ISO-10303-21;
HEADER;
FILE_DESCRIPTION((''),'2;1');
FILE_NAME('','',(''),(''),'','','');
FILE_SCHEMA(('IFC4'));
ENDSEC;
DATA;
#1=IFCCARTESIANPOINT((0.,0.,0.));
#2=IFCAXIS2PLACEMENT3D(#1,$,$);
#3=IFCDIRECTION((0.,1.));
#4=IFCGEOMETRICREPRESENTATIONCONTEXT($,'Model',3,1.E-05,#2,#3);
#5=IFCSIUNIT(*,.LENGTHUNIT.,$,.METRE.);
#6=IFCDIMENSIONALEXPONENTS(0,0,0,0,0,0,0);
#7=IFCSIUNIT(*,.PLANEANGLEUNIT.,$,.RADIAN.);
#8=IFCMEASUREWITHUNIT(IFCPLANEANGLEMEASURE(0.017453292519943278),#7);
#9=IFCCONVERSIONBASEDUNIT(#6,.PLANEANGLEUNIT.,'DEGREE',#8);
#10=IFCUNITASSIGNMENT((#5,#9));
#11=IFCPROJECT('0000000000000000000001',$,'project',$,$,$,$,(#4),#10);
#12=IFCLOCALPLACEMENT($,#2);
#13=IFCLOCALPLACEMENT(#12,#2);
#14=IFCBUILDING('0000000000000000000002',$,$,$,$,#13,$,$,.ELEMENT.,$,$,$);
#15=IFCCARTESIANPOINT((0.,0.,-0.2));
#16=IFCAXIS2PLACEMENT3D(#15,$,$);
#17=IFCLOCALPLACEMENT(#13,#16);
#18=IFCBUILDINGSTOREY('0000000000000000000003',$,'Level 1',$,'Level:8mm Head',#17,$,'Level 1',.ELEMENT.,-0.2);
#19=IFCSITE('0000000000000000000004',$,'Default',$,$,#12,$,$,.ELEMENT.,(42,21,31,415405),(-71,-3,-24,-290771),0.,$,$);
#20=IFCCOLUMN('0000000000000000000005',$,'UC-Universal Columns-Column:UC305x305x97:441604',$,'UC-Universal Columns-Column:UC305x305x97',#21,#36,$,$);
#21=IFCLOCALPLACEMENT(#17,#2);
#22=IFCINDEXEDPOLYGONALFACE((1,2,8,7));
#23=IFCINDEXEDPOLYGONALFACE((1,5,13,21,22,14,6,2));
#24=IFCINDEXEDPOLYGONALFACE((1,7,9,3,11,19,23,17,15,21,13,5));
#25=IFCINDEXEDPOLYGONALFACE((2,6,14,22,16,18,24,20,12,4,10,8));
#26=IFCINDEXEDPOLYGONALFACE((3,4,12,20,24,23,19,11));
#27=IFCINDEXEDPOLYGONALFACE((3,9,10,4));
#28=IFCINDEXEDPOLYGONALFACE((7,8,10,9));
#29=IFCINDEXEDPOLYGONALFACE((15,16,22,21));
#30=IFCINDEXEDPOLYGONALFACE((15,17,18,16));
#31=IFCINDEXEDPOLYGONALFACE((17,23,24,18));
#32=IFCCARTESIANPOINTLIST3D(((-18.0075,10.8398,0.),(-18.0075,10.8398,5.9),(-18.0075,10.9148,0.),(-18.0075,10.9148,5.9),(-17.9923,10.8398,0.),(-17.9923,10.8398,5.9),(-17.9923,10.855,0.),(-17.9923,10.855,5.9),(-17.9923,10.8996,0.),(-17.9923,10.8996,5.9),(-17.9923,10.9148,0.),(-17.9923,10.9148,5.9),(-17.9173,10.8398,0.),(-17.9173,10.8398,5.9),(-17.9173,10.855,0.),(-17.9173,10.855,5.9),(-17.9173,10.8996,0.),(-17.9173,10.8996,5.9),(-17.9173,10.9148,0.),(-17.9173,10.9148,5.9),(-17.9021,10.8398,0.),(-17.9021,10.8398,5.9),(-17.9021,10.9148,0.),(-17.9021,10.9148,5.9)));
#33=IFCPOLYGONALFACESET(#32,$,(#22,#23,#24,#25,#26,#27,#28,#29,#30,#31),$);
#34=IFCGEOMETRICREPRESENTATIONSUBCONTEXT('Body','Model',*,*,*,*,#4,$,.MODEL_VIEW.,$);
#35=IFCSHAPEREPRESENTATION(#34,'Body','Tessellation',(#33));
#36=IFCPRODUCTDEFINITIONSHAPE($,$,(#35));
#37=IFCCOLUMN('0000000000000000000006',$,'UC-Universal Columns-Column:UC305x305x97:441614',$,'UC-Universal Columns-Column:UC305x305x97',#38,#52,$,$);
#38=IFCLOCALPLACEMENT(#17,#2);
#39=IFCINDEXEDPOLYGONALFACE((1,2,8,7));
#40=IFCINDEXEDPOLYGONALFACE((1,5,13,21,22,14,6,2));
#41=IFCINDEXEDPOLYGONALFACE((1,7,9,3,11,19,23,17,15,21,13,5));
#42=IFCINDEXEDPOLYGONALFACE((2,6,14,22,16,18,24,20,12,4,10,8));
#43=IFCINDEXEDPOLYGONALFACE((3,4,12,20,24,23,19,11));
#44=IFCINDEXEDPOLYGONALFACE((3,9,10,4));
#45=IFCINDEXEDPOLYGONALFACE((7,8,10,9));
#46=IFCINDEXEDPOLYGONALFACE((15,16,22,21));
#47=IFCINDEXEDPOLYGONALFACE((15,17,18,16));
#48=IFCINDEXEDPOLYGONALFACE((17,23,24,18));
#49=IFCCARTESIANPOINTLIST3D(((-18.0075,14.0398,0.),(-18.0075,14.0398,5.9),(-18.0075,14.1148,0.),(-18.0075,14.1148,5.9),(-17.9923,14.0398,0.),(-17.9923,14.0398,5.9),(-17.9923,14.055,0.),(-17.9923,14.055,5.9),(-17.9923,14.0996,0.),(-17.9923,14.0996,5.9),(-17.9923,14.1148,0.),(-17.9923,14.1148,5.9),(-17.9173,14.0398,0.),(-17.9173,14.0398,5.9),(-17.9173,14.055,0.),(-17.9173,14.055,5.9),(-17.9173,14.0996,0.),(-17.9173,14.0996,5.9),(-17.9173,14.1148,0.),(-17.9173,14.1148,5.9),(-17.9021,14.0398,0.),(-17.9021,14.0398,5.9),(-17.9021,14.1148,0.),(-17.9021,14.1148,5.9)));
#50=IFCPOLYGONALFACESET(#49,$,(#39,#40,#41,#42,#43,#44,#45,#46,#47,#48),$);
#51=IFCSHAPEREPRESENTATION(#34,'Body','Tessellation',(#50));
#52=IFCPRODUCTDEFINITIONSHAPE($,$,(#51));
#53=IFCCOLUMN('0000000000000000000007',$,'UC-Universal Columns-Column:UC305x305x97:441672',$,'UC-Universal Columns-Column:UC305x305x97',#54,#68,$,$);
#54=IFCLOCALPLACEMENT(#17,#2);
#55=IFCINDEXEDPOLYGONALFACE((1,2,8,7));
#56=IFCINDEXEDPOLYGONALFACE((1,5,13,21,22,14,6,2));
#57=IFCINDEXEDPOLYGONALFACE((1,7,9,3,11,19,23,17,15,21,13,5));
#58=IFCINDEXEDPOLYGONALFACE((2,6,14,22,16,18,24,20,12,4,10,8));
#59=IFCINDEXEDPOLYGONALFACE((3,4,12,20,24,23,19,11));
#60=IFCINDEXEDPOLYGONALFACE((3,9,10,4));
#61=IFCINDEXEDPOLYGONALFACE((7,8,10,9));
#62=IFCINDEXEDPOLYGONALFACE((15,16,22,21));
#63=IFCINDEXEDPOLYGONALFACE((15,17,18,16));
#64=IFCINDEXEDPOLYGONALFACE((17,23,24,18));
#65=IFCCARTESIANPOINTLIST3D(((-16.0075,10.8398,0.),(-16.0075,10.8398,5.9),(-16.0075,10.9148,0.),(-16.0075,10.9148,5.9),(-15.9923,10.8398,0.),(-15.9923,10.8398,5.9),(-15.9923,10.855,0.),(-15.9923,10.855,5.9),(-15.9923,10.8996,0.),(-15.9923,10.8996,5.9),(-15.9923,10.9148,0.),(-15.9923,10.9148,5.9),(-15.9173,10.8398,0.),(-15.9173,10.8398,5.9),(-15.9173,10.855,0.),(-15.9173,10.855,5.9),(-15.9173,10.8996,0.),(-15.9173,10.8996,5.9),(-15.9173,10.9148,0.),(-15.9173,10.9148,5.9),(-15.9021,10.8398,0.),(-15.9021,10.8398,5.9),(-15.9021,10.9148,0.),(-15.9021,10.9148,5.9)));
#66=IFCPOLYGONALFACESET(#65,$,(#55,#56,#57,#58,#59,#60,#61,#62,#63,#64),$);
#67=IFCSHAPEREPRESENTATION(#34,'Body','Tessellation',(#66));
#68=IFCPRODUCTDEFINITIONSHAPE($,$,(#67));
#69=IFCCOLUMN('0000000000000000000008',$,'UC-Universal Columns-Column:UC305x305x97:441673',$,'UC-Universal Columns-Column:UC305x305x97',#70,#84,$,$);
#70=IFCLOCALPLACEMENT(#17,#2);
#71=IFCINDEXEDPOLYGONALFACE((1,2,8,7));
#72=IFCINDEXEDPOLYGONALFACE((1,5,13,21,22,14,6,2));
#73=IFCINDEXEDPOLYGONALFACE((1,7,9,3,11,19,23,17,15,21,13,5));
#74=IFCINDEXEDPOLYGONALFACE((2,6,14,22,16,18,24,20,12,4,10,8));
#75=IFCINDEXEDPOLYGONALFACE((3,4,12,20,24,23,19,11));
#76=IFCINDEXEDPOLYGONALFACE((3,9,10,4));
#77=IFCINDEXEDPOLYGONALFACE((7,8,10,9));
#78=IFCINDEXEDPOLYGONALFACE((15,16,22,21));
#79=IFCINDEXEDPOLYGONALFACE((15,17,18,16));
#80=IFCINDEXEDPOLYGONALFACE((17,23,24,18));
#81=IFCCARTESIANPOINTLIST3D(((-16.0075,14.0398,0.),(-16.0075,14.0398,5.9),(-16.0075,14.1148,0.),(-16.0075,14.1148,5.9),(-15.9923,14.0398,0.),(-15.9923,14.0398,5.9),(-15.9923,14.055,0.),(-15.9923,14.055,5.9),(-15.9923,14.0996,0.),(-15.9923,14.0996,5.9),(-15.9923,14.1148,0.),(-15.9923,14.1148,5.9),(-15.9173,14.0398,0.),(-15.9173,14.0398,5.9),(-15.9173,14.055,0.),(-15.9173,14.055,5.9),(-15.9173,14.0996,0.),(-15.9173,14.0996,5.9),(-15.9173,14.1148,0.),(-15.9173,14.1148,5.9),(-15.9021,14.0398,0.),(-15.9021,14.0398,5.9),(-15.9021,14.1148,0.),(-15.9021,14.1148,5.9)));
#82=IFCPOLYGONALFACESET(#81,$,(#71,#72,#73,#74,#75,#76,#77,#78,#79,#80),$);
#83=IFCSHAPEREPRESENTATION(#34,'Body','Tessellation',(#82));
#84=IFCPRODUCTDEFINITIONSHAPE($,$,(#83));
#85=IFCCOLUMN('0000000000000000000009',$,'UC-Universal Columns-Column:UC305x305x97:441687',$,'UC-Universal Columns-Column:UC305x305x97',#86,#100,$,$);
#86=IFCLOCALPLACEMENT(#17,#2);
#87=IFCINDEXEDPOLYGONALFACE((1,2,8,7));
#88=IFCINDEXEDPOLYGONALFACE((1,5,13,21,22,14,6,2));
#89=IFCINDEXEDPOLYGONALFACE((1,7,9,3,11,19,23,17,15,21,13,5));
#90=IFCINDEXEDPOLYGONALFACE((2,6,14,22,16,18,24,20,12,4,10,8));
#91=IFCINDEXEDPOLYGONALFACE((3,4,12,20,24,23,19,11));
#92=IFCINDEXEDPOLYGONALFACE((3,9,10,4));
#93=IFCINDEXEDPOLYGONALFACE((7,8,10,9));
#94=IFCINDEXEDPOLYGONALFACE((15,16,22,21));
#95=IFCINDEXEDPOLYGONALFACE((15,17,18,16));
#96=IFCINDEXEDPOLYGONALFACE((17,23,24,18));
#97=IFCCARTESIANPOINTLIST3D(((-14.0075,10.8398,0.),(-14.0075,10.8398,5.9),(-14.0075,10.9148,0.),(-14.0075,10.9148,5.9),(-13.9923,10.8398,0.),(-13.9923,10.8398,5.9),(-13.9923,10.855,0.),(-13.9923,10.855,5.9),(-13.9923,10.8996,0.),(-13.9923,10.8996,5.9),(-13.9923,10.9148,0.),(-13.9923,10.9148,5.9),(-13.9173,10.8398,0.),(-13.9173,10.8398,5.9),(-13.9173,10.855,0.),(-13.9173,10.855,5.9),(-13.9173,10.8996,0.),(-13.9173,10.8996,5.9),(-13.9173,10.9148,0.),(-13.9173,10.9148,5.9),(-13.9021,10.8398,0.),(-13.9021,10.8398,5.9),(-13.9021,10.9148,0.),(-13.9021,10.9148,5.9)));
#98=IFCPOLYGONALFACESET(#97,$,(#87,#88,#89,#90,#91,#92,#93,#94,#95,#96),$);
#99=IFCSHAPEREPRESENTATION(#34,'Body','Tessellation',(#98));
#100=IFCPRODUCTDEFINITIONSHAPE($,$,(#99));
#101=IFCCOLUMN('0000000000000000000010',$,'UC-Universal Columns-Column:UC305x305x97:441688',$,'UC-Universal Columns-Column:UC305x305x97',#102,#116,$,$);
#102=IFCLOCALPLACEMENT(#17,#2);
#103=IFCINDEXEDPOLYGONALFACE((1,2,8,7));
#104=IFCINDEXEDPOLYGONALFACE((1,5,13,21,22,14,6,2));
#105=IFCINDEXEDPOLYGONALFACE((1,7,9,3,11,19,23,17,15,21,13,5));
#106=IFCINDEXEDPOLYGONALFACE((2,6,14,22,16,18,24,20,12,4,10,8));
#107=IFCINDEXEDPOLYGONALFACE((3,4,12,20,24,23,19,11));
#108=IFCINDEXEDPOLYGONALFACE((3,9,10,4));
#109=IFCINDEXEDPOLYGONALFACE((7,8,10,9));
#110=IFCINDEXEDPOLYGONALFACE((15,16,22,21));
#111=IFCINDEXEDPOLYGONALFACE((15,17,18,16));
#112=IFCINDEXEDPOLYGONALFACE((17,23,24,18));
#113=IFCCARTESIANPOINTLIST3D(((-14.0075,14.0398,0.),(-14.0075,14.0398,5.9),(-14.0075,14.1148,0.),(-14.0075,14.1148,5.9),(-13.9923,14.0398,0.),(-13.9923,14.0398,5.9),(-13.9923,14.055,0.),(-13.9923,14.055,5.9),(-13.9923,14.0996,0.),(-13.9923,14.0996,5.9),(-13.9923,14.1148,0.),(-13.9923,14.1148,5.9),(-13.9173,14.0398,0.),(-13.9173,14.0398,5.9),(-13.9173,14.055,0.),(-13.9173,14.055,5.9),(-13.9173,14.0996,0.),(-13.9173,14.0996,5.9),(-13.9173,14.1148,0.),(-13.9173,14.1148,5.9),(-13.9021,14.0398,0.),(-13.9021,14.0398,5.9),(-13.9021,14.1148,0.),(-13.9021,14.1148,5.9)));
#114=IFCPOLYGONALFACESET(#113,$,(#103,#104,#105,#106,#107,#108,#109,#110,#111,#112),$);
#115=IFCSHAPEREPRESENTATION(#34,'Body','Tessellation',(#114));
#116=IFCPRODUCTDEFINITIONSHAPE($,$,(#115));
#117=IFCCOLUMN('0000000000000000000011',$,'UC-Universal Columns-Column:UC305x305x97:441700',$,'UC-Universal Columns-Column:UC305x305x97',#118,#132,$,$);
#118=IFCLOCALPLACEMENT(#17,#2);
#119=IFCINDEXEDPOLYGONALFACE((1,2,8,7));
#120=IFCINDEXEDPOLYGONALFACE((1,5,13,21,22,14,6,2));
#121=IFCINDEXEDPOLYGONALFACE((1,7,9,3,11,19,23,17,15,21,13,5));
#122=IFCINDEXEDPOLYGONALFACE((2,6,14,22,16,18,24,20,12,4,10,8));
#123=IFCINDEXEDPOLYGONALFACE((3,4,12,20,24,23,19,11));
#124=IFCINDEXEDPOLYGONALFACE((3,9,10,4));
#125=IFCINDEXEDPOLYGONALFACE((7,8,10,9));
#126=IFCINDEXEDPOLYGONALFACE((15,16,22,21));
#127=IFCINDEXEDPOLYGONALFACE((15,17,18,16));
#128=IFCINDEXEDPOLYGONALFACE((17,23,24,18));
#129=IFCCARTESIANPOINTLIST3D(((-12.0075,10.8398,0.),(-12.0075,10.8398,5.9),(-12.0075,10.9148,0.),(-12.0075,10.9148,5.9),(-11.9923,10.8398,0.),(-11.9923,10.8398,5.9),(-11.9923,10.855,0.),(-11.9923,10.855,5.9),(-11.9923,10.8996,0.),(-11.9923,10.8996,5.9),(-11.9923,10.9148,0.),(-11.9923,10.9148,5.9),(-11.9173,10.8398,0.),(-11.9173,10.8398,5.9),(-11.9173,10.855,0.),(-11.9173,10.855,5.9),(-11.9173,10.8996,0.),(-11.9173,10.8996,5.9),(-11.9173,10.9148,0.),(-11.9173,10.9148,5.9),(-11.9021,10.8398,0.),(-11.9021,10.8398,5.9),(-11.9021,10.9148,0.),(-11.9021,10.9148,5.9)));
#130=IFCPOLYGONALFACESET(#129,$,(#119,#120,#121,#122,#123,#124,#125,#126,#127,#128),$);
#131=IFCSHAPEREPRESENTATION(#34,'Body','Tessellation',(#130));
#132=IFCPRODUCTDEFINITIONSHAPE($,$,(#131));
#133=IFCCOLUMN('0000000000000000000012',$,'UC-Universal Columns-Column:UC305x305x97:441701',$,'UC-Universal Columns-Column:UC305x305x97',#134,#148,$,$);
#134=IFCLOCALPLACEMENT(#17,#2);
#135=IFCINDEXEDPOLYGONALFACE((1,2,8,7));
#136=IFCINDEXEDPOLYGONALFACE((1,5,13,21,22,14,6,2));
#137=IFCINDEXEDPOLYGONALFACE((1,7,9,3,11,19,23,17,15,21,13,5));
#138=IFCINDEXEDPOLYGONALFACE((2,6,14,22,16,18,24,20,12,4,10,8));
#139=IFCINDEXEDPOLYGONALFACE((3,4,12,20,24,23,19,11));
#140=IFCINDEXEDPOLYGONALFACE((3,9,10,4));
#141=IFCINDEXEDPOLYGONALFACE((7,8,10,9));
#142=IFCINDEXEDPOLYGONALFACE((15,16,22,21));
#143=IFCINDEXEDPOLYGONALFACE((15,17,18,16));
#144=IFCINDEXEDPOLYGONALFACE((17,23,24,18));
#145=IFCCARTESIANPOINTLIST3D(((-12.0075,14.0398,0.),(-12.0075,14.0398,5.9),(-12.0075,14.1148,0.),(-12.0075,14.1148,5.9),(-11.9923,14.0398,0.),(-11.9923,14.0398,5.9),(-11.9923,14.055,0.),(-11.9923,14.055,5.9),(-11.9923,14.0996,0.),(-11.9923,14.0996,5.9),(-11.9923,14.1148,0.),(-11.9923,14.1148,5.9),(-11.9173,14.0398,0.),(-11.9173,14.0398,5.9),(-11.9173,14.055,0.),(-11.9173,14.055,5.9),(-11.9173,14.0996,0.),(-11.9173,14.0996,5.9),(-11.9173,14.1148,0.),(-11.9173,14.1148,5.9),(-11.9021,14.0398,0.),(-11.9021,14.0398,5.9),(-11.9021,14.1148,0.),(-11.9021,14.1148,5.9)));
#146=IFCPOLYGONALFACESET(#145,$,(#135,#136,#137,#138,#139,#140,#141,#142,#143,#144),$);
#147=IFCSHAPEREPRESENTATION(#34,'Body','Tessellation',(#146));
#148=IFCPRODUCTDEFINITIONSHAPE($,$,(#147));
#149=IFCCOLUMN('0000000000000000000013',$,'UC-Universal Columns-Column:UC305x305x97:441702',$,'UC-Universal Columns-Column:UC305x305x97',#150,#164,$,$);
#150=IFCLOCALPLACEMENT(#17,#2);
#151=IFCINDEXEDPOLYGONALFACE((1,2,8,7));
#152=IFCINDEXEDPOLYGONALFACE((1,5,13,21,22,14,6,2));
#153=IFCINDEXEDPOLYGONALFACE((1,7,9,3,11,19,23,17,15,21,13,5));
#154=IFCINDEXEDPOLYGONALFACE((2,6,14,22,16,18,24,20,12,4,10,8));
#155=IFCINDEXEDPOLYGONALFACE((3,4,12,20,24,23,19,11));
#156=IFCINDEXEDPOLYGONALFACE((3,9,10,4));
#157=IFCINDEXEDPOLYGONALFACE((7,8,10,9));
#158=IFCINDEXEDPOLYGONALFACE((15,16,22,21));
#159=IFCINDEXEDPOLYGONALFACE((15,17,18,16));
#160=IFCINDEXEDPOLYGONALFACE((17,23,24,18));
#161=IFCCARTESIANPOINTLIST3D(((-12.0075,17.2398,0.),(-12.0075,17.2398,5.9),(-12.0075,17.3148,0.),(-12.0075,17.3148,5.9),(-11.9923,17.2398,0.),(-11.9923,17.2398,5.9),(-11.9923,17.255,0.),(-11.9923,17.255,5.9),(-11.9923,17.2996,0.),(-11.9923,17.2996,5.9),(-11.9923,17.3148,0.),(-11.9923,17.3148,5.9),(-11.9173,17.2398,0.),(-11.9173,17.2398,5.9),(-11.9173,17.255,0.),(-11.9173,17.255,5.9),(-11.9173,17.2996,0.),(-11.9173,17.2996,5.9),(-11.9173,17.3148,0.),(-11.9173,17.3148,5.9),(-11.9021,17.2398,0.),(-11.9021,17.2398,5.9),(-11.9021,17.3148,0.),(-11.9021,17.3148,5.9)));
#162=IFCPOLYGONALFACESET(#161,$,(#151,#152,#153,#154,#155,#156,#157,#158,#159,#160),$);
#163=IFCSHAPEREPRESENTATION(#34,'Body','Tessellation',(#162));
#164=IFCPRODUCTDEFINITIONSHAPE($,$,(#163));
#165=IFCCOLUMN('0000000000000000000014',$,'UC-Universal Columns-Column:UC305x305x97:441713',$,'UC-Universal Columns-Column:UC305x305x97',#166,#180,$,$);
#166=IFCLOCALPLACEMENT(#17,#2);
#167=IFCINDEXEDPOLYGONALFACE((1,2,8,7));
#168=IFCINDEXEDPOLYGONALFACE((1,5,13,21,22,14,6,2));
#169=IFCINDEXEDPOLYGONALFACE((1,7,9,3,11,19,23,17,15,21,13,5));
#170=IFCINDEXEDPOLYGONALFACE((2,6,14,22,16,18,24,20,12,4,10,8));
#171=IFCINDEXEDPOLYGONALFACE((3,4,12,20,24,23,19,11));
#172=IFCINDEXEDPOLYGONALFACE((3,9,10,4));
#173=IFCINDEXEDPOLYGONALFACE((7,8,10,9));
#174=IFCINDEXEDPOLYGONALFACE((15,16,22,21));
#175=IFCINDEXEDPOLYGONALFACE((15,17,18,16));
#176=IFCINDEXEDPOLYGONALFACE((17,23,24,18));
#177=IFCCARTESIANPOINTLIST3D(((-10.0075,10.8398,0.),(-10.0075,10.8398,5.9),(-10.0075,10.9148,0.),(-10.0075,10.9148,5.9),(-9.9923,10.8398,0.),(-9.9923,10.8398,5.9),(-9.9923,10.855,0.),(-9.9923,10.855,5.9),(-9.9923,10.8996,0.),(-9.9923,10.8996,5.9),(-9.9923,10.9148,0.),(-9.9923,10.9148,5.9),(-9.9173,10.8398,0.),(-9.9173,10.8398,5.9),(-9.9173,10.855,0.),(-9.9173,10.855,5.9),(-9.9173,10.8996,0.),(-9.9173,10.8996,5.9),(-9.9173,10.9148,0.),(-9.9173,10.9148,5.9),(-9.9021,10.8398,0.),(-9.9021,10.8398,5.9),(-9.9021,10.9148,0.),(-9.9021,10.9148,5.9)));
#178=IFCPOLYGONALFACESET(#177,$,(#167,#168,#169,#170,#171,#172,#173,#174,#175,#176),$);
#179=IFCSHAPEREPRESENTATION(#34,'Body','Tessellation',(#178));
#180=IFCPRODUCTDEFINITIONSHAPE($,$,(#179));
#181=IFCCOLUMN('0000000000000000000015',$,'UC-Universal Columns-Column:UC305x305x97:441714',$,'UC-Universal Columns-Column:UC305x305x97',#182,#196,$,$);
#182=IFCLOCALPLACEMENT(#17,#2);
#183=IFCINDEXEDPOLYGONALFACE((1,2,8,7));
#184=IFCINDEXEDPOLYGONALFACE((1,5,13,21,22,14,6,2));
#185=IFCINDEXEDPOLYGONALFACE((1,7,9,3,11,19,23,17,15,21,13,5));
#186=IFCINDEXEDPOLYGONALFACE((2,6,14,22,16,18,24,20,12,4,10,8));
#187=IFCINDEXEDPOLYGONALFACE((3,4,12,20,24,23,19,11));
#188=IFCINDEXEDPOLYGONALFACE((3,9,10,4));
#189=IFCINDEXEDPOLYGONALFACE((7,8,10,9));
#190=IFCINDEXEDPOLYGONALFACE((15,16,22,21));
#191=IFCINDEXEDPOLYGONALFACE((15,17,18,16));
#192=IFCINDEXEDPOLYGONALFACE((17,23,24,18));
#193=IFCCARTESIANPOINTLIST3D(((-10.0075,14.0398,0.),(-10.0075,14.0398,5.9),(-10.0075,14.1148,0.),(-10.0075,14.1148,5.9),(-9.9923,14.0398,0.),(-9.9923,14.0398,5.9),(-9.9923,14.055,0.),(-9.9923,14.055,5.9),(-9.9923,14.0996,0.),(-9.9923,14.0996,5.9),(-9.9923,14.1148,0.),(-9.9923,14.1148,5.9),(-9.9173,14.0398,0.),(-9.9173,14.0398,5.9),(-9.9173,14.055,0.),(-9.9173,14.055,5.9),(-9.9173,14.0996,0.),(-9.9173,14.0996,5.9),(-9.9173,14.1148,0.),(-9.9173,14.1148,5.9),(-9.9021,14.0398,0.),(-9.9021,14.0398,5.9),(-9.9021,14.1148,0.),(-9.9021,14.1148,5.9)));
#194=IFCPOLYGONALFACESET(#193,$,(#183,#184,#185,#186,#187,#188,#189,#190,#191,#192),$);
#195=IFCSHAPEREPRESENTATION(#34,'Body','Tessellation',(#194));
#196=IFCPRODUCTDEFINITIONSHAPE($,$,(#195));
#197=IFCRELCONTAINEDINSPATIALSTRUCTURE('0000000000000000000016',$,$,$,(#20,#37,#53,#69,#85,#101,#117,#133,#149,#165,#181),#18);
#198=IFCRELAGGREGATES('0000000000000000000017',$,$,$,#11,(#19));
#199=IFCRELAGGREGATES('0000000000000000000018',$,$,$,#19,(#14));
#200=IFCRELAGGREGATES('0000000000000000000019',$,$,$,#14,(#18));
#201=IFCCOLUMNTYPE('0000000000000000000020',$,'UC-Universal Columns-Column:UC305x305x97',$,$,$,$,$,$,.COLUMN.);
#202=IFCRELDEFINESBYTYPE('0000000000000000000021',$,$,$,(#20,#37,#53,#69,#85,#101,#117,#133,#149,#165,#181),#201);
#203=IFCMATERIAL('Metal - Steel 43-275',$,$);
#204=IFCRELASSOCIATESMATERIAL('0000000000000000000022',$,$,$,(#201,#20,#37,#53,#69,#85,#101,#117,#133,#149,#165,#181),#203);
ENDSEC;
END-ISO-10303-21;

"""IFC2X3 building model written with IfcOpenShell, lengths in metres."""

from ifc_helpers import new_model, entity, si_unit, converted_unit, direction, frame, frame_2d, origin, place, context, subcontext, project, spatial, polyline, circle_curve, parameter, trimmed, segment, composite_curve, outline, extrude, source, transform, mapped, material, type_object, type_shapes, element, save


model = new_model("IFC2X3")

# Units and contexts
model_context = context("Model", 3, precision=1e-05, world=origin(), true_north=direction((0.0, 1.0)))
body_context = subcontext(model_context, "Body", "Model", "MODEL_VIEW")
ifc_project = project(units=[si_unit("LENGTHUNIT", "METRE"), converted_unit("PLANEANGLEUNIT", "DEGREE", entity("IfcPlaneAngleMeasure", 0.017453292519943278), si_unit("PLANEANGLEUNIT", "RADIAN"), dimensions=[0, 0, 0, 0, 0, 0, 0])], contexts=[model_context])

# Site, building, storey
site_placement = place(None, origin())
site = spatial("IfcSite", under=ifc_project, at=site_placement, Name="Default", CompositionType="ELEMENT", RefLatitude=(42, 21, 31, 415405), RefLongitude=(-71, -3, -24, -290771), RefElevation=0.0)
building_placement = place(site_placement, origin())
building = spatial("IfcBuilding", under=site, at=building_placement, CompositionType="ELEMENT")
storey_placement = place(building_placement, frame((0.0, 0.0, -0.2)))
storey = spatial("IfcBuildingStorey", under=building, at=storey_placement, Name="Level 1", ObjectType="Level:8mm Head", LongName="Level 1", CompositionType="ELEMENT", Elevation=-0.2)

# Columns
ifc_material = material(Name="Metal - Steel 43-275")
column_type = type_object("IfcColumnType", Name="UC-Universal Columns-Column:UC305x305x97", PredefinedType="COLUMN", material=ifc_material)
shared_shape = source(origin(), body_context, "Body", "SweptSolid", [
    extrude(outline(composite_curve([segment(polyline([(-0.0375, -0.0375), (0.0375, -0.0375)]), True, "CONTINUOUS"), segment(polyline([(0.0375, -0.0375), (0.0527, -0.0375)]), True, "CONTINUOUS"), segment(trimmed(circle_curve(frame_2d((0.0527, -0.0223), x_axis=(-1.0, 0.0)), 0.0152), [parameter(0.0)], [parameter(90.0)], True, "PARAMETER"), False, "CONTINUOUS"), segment(polyline([(0.0375, -0.0223), (0.0375, 0.0223)]), True, "CONTINUOUS"), segment(trimmed(circle_curve(frame_2d((0.0527, 0.0223), x_axis=(-1.0, 0.0)), 0.0152), [parameter(270.0)], [parameter(0.0)], True, "PARAMETER"), False, "CONTINUOUS"), segment(polyline([(0.0527, 0.0375), (0.0375, 0.0375)]), True, "CONTINUOUS"), segment(polyline([(0.0375, 0.0375), (-0.0375, 0.0375)]), True, "CONTINUOUS"), segment(polyline([(-0.0375, 0.0375), (-0.0527, 0.0375)]), True, "CONTINUOUS"), segment(trimmed(circle_curve(frame_2d((-0.0527, 0.0223), x_axis=(-1.0, 0.0)), 0.0152), [parameter(180.0)], [parameter(270.0)], True, "PARAMETER"), False, "CONTINUOUS"), segment(polyline([(-0.0375, 0.0223), (-0.0375, -0.0223)]), True, "CONTINUOUS"), segment(trimmed(circle_curve(frame_2d((-0.0527, -0.0223), x_axis=(-1.0, 0.0)), 0.0152), [parameter(90.0)], [parameter(180.0)], True, "PARAMETER"), False, "CONTINUOUS"), segment(polyline([(-0.0527, -0.0375), (-0.0375, -0.0375)]), True, "CONTINUOUS")], self_intersect=False)), frame((0.0, 0.0, -0.2), z_axis=(0.0, 0.0, 1.0), x_axis=(-1.0, 0.0, 0.0)), (0.0, 0.0, 1.0), 5.9),
])
type_shapes(column_type, [shared_shape])
for number, where, z_axis, x_axis, name in (
    (1, (-17.9548, 10.8773, 0.2), (0.0, 0.0, 1.0), (-1.0, 0.0, 0.0), "UC-Universal Columns-Column:UC305x305x97:441604"),
    (2, (-17.9548, 14.0773, 0.2), (0.0, 0.0, 1.0), (-1.0, 0.0, 0.0), "UC-Universal Columns-Column:UC305x305x97:441614"),
    (3, (-15.9548, 10.8773, 0.2), (0.0, 0.0, 1.0), (-1.0, 0.0, 0.0), "UC-Universal Columns-Column:UC305x305x97:441672"),
    (4, (-15.9548, 14.0773, 0.2), (0.0, 0.0, 1.0), (-1.0, 0.0, 0.0), "UC-Universal Columns-Column:UC305x305x97:441673"),
    (5, (-13.9548, 10.8773, 0.2), (0.0, 0.0, 1.0), (-1.0, 0.0, 0.0), "UC-Universal Columns-Column:UC305x305x97:441687"),
    (6, (-13.9548, 14.0773, 0.2), (0.0, 0.0, 1.0), (-1.0, 0.0, 0.0), "UC-Universal Columns-Column:UC305x305x97:441688"),
    (7, (-11.9548, 10.8773, 0.2), (0.0, 0.0, 1.0), (-1.0, 0.0, 0.0), "UC-Universal Columns-Column:UC305x305x97:441700"),
    (8, (-11.9548, 14.0773, 0.2), (0.0, 0.0, 1.0), (-1.0, 0.0, 0.0), "UC-Universal Columns-Column:UC305x305x97:441701"),
    (9, (-11.9548, 17.2773, 0.2), (0.0, 0.0, 1.0), (-1.0, 0.0, 0.0), "UC-Universal Columns-Column:UC305x305x97:441702"),
    (10, (-9.9548, 10.8773, 0.2), (0.0, 0.0, 1.0), (-1.0, 0.0, 0.0), "UC-Universal Columns-Column:UC305x305x97:441713"),
    (11, (-9.9548, 14.0773, 0.2), (0.0, 0.0, 1.0), (-1.0, 0.0, 0.0), "UC-Universal Columns-Column:UC305x305x97:441714"),
):
    element("IfcColumn", number, at=place(storey_placement, frame(where, z_axis=z_axis, x_axis=x_axis)), inside=storey, type_object=column_type, material=ifc_material, Name=name, ObjectType="UC-Universal Columns-Column:UC305x305x97", context=body_context, shape_type="MappedRepresentation", body=[
        mapped(shared_shape, transform((0.0, 0.0, 0.0), scale=1.0)),
    ])

save(model, "model.ifc")
